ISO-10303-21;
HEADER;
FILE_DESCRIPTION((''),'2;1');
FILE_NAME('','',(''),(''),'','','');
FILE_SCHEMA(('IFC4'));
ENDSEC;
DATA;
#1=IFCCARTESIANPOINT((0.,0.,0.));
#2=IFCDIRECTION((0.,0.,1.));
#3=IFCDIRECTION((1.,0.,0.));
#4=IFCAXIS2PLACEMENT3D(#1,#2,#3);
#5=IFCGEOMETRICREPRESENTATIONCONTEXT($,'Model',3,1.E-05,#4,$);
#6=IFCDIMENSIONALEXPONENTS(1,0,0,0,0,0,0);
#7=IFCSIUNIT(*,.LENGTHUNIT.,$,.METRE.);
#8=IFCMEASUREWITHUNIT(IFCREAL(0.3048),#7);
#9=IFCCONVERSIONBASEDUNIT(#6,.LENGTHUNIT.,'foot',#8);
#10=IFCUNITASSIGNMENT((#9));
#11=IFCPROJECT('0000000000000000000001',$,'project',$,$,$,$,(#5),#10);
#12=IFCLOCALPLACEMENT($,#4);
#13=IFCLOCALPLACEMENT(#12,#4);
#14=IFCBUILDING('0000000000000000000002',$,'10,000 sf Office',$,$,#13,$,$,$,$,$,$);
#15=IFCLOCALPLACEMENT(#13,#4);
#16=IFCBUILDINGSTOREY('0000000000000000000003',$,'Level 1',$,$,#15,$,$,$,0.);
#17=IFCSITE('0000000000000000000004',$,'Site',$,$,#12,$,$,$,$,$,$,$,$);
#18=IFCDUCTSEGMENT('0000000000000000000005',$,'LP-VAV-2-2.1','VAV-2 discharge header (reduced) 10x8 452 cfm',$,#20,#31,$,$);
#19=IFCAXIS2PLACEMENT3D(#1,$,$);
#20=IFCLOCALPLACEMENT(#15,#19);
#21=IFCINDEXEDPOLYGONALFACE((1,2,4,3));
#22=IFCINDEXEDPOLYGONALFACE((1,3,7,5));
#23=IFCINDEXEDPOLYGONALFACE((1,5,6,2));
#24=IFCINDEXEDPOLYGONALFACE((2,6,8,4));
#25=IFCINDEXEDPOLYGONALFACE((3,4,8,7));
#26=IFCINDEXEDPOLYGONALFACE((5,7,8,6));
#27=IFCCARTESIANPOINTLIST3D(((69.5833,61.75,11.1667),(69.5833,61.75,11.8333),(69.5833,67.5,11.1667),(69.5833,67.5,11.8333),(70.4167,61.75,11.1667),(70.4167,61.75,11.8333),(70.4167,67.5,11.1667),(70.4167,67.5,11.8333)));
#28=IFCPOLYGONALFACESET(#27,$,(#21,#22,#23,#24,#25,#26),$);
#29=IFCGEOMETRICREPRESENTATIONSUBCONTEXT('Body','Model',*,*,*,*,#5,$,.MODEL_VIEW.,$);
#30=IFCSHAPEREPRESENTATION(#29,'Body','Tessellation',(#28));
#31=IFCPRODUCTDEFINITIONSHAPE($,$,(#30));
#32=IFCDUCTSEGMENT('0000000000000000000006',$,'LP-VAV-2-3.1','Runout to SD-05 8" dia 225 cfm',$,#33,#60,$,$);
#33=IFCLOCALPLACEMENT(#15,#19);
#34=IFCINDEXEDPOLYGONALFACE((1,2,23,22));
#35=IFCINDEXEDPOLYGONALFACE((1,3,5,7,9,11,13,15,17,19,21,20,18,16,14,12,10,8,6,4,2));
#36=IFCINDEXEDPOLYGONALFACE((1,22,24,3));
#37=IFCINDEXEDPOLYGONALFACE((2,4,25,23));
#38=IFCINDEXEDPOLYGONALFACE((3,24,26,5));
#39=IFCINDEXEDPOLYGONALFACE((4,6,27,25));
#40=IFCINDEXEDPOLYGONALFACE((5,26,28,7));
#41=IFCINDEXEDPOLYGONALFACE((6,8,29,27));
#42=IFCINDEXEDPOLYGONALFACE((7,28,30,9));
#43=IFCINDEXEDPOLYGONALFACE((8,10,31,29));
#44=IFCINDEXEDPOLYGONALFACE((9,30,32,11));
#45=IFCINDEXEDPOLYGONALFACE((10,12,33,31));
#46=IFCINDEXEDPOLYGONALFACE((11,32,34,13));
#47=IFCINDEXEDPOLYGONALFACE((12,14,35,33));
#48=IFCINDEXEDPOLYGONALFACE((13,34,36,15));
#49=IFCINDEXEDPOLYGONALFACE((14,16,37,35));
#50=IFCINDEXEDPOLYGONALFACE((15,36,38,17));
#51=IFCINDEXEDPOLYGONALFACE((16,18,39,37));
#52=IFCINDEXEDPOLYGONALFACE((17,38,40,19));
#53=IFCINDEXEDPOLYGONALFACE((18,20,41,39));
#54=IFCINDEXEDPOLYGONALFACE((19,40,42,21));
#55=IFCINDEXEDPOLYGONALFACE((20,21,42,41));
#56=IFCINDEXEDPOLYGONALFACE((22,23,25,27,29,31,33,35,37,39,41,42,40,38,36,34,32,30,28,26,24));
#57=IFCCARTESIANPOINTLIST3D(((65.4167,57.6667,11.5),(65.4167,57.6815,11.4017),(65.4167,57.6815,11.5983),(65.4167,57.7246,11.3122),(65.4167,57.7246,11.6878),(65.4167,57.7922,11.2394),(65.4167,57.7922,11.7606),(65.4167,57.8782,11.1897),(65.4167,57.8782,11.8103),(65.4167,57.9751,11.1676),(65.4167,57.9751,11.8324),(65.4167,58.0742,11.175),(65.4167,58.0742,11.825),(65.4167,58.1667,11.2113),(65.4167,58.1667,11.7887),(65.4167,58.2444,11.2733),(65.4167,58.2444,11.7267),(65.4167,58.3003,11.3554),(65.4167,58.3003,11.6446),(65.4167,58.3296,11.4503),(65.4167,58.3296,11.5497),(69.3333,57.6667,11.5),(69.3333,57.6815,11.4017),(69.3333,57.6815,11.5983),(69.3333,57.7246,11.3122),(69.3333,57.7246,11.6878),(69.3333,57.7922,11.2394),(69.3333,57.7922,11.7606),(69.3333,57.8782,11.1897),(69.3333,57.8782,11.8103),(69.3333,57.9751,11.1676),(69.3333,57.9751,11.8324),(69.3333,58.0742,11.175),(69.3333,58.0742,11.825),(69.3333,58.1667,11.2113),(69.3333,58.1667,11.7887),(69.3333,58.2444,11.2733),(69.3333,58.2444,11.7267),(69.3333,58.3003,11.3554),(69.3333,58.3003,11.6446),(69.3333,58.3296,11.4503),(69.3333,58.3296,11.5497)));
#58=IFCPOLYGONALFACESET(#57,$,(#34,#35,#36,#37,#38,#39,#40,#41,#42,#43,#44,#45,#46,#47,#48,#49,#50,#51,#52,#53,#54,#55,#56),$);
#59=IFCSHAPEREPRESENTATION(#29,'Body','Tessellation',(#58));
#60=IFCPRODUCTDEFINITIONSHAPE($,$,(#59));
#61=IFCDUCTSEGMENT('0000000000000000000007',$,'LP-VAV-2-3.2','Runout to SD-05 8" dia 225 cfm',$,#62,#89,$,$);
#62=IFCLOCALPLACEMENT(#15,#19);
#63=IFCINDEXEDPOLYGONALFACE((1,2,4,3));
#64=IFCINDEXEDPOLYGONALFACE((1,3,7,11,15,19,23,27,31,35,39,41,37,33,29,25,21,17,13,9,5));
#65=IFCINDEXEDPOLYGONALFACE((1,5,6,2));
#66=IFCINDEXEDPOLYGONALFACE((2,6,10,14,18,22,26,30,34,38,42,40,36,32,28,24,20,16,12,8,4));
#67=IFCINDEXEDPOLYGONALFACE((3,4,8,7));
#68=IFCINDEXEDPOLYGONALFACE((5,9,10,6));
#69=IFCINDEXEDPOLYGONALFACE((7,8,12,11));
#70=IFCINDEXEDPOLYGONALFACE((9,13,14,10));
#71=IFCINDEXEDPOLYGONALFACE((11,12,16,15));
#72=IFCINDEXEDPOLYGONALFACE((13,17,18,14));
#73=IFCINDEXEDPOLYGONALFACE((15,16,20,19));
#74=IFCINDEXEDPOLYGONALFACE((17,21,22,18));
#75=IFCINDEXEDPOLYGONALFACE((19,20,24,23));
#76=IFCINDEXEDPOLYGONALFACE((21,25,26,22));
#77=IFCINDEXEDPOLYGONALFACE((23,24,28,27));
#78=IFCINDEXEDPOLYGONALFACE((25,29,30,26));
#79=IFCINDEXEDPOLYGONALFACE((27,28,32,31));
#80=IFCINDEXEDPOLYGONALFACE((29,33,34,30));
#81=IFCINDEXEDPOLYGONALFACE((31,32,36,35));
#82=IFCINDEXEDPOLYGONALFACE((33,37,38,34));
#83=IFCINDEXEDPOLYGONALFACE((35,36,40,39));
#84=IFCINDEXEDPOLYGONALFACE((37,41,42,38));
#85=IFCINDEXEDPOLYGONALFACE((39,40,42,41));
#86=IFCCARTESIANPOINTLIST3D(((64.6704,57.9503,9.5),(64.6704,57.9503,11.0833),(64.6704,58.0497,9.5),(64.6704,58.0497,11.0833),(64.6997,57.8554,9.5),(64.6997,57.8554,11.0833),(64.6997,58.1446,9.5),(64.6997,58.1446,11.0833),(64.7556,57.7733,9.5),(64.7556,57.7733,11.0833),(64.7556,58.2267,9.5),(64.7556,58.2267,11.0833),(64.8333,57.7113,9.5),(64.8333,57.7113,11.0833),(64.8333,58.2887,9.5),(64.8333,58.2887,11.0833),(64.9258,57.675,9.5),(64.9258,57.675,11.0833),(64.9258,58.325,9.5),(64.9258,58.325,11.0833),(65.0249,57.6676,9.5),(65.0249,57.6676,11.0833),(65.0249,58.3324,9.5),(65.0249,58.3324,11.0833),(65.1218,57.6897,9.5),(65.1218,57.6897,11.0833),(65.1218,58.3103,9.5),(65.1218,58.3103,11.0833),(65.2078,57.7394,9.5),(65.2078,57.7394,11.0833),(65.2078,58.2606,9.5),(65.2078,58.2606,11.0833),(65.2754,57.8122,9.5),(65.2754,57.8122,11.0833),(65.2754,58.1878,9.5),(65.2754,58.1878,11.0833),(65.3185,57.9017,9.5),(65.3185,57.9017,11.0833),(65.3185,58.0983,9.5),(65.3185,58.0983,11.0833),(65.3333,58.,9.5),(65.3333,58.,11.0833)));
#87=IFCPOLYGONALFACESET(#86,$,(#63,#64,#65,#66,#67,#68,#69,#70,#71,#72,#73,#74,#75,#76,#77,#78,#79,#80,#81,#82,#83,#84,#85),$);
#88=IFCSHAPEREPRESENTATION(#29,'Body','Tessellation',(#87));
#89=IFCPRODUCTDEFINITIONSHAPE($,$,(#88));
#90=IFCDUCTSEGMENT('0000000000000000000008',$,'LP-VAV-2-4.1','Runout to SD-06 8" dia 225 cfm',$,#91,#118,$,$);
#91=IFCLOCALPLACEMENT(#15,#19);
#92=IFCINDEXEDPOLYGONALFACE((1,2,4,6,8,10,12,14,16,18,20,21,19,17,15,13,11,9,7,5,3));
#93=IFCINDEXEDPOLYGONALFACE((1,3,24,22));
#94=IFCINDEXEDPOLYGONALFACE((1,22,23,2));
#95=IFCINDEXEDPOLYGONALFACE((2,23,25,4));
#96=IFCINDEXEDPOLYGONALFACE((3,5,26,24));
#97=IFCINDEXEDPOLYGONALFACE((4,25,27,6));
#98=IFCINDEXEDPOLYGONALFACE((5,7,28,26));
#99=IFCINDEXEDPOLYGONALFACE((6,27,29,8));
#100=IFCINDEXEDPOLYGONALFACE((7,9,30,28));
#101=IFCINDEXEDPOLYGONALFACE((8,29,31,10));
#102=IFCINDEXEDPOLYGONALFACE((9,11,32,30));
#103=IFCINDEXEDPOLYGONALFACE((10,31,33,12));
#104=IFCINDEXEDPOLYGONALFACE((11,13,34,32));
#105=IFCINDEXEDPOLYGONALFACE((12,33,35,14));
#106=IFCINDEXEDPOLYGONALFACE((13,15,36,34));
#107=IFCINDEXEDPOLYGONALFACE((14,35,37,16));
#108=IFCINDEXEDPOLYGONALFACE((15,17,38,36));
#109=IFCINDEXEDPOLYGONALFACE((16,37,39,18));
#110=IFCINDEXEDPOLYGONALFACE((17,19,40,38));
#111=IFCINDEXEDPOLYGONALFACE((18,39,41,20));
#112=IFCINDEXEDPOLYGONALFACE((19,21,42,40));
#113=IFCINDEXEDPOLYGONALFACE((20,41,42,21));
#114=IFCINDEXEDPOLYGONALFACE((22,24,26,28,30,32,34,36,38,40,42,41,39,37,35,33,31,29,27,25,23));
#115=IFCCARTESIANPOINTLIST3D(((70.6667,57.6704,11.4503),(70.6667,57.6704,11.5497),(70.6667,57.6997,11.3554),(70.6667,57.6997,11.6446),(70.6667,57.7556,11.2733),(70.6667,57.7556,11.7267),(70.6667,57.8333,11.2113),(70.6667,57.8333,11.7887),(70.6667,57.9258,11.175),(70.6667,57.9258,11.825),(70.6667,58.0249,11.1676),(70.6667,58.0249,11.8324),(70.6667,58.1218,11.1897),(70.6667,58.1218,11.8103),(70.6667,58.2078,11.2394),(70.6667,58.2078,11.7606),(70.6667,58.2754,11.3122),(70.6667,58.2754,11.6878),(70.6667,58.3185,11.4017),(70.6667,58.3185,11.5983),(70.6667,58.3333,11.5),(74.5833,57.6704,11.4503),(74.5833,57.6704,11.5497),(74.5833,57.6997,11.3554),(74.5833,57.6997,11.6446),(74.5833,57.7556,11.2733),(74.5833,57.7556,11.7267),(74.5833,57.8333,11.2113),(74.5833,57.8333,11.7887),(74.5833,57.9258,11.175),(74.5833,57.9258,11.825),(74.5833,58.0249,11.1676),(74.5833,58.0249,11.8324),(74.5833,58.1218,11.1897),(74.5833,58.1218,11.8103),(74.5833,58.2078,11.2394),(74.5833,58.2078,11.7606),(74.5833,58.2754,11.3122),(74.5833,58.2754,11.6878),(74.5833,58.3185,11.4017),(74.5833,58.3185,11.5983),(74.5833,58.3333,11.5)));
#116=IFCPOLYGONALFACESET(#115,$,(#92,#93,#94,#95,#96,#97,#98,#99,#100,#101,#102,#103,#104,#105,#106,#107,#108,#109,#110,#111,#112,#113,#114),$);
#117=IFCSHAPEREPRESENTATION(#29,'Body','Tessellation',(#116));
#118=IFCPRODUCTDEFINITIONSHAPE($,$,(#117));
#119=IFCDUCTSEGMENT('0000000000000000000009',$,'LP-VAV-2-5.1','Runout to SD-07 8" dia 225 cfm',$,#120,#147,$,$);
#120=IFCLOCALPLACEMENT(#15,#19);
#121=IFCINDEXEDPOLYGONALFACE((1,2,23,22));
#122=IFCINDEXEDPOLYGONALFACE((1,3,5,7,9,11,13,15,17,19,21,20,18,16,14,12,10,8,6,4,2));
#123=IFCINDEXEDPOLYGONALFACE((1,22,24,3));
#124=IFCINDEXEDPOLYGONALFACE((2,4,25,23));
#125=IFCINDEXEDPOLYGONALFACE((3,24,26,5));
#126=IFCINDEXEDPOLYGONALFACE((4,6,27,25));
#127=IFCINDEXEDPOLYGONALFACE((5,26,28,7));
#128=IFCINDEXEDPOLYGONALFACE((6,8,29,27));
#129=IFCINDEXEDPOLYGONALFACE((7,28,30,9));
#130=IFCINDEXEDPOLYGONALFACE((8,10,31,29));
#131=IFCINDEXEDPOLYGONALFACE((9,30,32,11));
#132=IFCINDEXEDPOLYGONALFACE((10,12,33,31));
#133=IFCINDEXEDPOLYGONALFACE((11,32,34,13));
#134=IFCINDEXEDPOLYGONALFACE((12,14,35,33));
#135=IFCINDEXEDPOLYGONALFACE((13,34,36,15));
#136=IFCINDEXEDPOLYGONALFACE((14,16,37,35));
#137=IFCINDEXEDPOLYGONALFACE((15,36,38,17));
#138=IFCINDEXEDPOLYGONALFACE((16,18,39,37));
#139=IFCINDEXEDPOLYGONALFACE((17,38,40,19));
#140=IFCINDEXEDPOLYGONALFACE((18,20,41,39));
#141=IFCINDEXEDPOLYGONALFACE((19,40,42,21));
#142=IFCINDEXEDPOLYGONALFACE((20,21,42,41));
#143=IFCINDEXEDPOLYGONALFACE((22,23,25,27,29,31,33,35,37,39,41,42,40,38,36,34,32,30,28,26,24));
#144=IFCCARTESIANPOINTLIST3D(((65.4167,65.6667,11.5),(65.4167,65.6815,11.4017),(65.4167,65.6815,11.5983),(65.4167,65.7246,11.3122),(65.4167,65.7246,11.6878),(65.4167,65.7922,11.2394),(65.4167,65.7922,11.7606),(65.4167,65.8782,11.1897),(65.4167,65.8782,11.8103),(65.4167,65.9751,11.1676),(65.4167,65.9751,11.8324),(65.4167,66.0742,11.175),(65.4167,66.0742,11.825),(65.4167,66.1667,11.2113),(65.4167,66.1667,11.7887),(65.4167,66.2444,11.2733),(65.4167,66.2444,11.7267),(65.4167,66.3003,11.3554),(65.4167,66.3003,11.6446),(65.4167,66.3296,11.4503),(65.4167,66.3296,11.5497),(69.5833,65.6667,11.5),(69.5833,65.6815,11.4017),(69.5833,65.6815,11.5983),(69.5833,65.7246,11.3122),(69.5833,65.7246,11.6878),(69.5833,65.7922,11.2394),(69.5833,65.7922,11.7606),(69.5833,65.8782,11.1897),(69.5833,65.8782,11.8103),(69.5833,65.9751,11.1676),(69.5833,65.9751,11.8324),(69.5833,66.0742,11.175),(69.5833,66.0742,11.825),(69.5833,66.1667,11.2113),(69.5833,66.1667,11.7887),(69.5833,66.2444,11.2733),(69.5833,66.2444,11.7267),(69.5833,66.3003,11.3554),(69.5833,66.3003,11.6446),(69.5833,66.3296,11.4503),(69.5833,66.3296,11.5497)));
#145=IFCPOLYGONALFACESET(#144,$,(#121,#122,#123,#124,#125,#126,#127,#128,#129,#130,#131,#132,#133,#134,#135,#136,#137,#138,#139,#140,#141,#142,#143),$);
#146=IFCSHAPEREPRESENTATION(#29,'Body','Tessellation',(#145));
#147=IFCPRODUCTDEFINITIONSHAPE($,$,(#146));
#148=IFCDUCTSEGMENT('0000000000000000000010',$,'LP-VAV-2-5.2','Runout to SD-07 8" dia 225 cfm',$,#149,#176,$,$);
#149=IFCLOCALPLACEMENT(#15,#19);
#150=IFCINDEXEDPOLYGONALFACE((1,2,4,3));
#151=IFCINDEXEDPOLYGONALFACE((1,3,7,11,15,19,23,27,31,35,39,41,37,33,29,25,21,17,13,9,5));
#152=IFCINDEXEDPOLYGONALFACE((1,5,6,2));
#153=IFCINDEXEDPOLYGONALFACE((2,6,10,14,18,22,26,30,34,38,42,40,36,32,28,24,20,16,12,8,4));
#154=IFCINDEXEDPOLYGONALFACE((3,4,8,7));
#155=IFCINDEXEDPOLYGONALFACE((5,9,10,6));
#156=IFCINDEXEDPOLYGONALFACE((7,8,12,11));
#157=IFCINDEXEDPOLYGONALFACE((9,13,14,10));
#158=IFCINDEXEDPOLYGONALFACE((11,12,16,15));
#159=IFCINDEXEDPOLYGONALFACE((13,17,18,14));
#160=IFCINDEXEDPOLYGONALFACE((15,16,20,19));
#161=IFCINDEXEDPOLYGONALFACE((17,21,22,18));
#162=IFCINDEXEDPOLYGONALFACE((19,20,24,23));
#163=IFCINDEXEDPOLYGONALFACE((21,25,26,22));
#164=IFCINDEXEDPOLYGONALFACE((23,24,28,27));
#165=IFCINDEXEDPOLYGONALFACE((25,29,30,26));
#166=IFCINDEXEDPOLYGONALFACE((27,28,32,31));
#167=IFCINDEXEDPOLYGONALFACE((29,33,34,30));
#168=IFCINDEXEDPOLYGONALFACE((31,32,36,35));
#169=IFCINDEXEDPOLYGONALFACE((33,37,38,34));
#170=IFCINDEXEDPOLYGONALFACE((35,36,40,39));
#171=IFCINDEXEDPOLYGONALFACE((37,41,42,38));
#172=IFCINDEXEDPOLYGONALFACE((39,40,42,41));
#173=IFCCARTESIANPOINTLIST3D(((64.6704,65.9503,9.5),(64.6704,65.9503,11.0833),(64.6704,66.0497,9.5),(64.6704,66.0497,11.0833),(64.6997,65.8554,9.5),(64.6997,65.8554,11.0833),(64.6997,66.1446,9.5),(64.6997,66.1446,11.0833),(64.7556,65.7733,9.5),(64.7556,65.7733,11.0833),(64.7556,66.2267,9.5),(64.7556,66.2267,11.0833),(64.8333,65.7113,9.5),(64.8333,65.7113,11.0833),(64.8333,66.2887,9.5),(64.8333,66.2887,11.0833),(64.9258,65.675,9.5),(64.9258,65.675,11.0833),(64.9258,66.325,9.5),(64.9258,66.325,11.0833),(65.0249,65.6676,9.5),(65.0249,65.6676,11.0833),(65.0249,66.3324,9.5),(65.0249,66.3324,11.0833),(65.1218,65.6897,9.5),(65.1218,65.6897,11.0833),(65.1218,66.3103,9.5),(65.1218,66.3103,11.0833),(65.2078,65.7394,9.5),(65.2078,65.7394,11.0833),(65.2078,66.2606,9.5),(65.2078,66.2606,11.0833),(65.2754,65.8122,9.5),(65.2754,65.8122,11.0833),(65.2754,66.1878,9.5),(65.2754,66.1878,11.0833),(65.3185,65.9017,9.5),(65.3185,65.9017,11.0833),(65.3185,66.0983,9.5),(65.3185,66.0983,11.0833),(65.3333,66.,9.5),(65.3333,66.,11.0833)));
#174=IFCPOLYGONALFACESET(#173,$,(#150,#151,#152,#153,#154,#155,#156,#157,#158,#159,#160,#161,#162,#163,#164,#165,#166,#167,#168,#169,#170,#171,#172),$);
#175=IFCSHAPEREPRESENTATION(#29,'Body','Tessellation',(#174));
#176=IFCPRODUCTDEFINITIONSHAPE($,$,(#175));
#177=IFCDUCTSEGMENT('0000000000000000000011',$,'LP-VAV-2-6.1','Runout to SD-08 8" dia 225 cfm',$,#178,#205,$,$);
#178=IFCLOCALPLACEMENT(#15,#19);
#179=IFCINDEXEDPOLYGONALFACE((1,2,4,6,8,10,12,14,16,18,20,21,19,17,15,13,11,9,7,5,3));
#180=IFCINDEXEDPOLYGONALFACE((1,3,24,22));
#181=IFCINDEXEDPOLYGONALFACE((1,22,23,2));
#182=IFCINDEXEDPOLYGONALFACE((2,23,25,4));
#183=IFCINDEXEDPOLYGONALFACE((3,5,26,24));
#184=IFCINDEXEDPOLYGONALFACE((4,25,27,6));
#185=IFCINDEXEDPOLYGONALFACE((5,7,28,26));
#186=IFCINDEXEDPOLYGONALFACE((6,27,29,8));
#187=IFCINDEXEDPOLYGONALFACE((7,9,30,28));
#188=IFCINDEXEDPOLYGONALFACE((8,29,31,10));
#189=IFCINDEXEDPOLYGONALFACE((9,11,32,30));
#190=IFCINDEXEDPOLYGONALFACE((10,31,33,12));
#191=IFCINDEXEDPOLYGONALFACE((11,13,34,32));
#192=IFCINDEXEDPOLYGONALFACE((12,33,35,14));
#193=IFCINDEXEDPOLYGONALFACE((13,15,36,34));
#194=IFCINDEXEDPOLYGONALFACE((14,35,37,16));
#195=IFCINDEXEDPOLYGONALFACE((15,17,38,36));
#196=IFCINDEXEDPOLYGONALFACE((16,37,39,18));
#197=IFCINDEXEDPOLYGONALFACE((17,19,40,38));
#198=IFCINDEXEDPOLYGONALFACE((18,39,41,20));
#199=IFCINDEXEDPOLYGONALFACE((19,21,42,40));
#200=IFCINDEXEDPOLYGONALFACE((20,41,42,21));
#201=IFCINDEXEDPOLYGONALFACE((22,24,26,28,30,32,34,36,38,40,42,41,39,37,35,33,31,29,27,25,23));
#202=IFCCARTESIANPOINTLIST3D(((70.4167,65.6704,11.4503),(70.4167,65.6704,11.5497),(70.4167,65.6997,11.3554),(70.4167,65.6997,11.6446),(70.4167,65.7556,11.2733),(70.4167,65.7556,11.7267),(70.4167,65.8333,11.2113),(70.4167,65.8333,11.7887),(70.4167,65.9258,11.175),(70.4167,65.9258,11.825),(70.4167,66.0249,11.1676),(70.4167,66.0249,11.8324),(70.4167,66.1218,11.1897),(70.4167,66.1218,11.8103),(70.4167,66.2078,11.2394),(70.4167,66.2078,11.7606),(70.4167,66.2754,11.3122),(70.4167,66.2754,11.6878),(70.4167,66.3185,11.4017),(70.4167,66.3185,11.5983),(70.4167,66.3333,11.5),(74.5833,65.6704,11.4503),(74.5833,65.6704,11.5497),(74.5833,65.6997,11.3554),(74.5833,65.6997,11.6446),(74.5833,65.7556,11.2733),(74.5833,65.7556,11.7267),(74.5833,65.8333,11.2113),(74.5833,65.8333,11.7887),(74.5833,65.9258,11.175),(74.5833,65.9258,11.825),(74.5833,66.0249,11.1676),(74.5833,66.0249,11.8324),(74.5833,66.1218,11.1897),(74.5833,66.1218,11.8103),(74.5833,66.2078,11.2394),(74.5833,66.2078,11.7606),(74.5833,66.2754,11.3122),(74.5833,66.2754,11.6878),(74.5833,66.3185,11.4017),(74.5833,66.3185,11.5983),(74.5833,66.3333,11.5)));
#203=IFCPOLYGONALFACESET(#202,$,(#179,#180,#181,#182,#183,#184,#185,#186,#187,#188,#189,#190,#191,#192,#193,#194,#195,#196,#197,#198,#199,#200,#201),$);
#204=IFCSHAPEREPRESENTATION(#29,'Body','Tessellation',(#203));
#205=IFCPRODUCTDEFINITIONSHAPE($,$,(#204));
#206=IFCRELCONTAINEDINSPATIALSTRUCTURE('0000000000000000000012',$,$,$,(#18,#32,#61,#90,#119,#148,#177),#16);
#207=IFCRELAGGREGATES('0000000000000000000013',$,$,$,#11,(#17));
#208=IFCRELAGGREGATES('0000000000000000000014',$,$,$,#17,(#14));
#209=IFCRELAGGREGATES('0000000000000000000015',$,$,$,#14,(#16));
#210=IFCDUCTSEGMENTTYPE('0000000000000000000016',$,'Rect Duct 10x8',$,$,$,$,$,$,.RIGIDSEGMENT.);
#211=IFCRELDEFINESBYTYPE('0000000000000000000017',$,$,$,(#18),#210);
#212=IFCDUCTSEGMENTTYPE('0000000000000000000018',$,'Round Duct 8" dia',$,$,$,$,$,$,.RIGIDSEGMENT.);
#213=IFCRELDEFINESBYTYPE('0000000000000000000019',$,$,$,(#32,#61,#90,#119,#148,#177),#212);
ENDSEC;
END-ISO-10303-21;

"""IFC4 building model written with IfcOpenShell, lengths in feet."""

from ifc_helpers import new_model, entity, si_unit, converted_unit, frame, origin_with_axes, place, context, subcontext, project, spatial, rectangle, circle, extrude, type_object, element, save


model = new_model("IFC4")

# Units and contexts
model_context = context("Model", 3, precision=1e-05, world=origin_with_axes())
body_context = subcontext(model_context, "Body", "Model", "MODEL_VIEW")
ifc_project = project(units=[converted_unit("LENGTHUNIT", "foot", entity("IfcReal", 0.3048), si_unit("LENGTHUNIT", "METRE"), dimensions=[1, 0, 0, 0, 0, 0, 0])], contexts=[model_context])

# Site, building, storey
site_placement = place(None, origin_with_axes())
site = spatial("IfcSite", under=ifc_project, at=site_placement, Name="Site")
building_placement = place(site_placement, origin_with_axes())
building = spatial("IfcBuilding", under=site, at=building_placement, Name="10,000 sf Office")
storey_placement = place(building_placement, origin_with_axes())
storey = spatial("IfcBuildingStorey", under=building, at=storey_placement, Name="Level 1", Elevation=0.0)

# Duct segments
duct_segment_type_1 = type_object("IfcDuctSegmentType", Name="Rect Duct 10x8", PredefinedType="RIGIDSEGMENT")
duct_segment_1_placement = place(storey_placement, frame((70.0, 61.75, 11.5), z_axis=(0.0, 1.0, 0.0), x_axis=(-1.0, 0.0, 0.0)))
element("IfcDuctSegment", 1, at=duct_segment_1_placement, inside=storey, type_object=duct_segment_type_1, Name="LP-VAV-2-2.1", Description="VAV-2 discharge header (reduced) 10x8 452 cfm", context=body_context, shape_type="SweptSolid", body=[
    extrude(rectangle(XDim=0.8333, YDim=0.6667), None, (0.0, 0.0, 1.0), 5.75),
])
duct_segment_type_2 = type_object("IfcDuctSegmentType", Name="Round Duct 8\" dia", PredefinedType="RIGIDSEGMENT")
duct_segment_2_placement = place(storey_placement, frame((69.3333, 58.0, 11.5), z_axis=(-1.0, 0.0, 0.0), x_axis=(0.0, -1.0, 0.0)))
element("IfcDuctSegment", 2, at=duct_segment_2_placement, inside=storey, type_object=duct_segment_type_2, Name="LP-VAV-2-3.1", Description="Runout to SD-05 8\" dia 225 cfm", context=body_context, shape_type="SweptSolid", body=[
    extrude(circle(Radius=0.3333), None, (0.0, 0.0, 1.0), 3.9167),
])
duct_segment_3_placement = place(storey_placement, frame((65.0, 58.0, 11.0833), z_axis=(0.0, 0.0, -1.0), x_axis=(1.0, 0.0, 0.0)))
element("IfcDuctSegment", 3, at=duct_segment_3_placement, inside=storey, type_object=duct_segment_type_2, Name="LP-VAV-2-3.2", Description="Runout to SD-05 8\" dia 225 cfm", context=body_context, shape_type="SweptSolid", body=[
    extrude(circle(Radius=0.3333), None, (0.0, 0.0, 1.0), 1.5833),
])
duct_segment_4_placement = place(storey_placement, frame((70.6667, 58.0, 11.5), z_axis=(1.0, 0.0, 0.0), x_axis=(0.0, 1.0, 0.0)))
element("IfcDuctSegment", 4, at=duct_segment_4_placement, inside=storey, type_object=duct_segment_type_2, Name="LP-VAV-2-4.1", Description="Runout to SD-06 8\" dia 225 cfm", context=body_context, shape_type="SweptSolid", body=[
    extrude(circle(Radius=0.3333), None, (0.0, 0.0, 1.0), 3.9167),
])
duct_segment_5_placement = place(storey_placement, frame((69.5833, 66.0, 11.5), z_axis=(-1.0, 0.0, 0.0), x_axis=(0.0, -1.0, 0.0)))
element("IfcDuctSegment", 5, at=duct_segment_5_placement, inside=storey, type_object=duct_segment_type_2, Name="LP-VAV-2-5.1", Description="Runout to SD-07 8\" dia 225 cfm", context=body_context, shape_type="SweptSolid", body=[
    extrude(circle(Radius=0.3333), None, (0.0, 0.0, 1.0), 4.1667),
])
duct_segment_6_placement = place(storey_placement, frame((65.0, 66.0, 11.0833), z_axis=(0.0, 0.0, -1.0), x_axis=(1.0, 0.0, 0.0)))
element("IfcDuctSegment", 6, at=duct_segment_6_placement, inside=storey, type_object=duct_segment_type_2, Name="LP-VAV-2-5.2", Description="Runout to SD-07 8\" dia 225 cfm", context=body_context, shape_type="SweptSolid", body=[
    extrude(circle(Radius=0.3333), None, (0.0, 0.0, 1.0), 1.5833),
])
duct_segment_7_placement = place(storey_placement, frame((70.4167, 66.0, 11.5), z_axis=(1.0, 0.0, 0.0), x_axis=(0.0, 1.0, 0.0)))
element("IfcDuctSegment", 7, at=duct_segment_7_placement, inside=storey, type_object=duct_segment_type_2, Name="LP-VAV-2-6.1", Description="Runout to SD-08 8\" dia 225 cfm", context=body_context, shape_type="SweptSolid", body=[
    extrude(circle(Radius=0.3333), None, (0.0, 0.0, 1.0), 4.1667),
])

save(model, "model.ifc")
